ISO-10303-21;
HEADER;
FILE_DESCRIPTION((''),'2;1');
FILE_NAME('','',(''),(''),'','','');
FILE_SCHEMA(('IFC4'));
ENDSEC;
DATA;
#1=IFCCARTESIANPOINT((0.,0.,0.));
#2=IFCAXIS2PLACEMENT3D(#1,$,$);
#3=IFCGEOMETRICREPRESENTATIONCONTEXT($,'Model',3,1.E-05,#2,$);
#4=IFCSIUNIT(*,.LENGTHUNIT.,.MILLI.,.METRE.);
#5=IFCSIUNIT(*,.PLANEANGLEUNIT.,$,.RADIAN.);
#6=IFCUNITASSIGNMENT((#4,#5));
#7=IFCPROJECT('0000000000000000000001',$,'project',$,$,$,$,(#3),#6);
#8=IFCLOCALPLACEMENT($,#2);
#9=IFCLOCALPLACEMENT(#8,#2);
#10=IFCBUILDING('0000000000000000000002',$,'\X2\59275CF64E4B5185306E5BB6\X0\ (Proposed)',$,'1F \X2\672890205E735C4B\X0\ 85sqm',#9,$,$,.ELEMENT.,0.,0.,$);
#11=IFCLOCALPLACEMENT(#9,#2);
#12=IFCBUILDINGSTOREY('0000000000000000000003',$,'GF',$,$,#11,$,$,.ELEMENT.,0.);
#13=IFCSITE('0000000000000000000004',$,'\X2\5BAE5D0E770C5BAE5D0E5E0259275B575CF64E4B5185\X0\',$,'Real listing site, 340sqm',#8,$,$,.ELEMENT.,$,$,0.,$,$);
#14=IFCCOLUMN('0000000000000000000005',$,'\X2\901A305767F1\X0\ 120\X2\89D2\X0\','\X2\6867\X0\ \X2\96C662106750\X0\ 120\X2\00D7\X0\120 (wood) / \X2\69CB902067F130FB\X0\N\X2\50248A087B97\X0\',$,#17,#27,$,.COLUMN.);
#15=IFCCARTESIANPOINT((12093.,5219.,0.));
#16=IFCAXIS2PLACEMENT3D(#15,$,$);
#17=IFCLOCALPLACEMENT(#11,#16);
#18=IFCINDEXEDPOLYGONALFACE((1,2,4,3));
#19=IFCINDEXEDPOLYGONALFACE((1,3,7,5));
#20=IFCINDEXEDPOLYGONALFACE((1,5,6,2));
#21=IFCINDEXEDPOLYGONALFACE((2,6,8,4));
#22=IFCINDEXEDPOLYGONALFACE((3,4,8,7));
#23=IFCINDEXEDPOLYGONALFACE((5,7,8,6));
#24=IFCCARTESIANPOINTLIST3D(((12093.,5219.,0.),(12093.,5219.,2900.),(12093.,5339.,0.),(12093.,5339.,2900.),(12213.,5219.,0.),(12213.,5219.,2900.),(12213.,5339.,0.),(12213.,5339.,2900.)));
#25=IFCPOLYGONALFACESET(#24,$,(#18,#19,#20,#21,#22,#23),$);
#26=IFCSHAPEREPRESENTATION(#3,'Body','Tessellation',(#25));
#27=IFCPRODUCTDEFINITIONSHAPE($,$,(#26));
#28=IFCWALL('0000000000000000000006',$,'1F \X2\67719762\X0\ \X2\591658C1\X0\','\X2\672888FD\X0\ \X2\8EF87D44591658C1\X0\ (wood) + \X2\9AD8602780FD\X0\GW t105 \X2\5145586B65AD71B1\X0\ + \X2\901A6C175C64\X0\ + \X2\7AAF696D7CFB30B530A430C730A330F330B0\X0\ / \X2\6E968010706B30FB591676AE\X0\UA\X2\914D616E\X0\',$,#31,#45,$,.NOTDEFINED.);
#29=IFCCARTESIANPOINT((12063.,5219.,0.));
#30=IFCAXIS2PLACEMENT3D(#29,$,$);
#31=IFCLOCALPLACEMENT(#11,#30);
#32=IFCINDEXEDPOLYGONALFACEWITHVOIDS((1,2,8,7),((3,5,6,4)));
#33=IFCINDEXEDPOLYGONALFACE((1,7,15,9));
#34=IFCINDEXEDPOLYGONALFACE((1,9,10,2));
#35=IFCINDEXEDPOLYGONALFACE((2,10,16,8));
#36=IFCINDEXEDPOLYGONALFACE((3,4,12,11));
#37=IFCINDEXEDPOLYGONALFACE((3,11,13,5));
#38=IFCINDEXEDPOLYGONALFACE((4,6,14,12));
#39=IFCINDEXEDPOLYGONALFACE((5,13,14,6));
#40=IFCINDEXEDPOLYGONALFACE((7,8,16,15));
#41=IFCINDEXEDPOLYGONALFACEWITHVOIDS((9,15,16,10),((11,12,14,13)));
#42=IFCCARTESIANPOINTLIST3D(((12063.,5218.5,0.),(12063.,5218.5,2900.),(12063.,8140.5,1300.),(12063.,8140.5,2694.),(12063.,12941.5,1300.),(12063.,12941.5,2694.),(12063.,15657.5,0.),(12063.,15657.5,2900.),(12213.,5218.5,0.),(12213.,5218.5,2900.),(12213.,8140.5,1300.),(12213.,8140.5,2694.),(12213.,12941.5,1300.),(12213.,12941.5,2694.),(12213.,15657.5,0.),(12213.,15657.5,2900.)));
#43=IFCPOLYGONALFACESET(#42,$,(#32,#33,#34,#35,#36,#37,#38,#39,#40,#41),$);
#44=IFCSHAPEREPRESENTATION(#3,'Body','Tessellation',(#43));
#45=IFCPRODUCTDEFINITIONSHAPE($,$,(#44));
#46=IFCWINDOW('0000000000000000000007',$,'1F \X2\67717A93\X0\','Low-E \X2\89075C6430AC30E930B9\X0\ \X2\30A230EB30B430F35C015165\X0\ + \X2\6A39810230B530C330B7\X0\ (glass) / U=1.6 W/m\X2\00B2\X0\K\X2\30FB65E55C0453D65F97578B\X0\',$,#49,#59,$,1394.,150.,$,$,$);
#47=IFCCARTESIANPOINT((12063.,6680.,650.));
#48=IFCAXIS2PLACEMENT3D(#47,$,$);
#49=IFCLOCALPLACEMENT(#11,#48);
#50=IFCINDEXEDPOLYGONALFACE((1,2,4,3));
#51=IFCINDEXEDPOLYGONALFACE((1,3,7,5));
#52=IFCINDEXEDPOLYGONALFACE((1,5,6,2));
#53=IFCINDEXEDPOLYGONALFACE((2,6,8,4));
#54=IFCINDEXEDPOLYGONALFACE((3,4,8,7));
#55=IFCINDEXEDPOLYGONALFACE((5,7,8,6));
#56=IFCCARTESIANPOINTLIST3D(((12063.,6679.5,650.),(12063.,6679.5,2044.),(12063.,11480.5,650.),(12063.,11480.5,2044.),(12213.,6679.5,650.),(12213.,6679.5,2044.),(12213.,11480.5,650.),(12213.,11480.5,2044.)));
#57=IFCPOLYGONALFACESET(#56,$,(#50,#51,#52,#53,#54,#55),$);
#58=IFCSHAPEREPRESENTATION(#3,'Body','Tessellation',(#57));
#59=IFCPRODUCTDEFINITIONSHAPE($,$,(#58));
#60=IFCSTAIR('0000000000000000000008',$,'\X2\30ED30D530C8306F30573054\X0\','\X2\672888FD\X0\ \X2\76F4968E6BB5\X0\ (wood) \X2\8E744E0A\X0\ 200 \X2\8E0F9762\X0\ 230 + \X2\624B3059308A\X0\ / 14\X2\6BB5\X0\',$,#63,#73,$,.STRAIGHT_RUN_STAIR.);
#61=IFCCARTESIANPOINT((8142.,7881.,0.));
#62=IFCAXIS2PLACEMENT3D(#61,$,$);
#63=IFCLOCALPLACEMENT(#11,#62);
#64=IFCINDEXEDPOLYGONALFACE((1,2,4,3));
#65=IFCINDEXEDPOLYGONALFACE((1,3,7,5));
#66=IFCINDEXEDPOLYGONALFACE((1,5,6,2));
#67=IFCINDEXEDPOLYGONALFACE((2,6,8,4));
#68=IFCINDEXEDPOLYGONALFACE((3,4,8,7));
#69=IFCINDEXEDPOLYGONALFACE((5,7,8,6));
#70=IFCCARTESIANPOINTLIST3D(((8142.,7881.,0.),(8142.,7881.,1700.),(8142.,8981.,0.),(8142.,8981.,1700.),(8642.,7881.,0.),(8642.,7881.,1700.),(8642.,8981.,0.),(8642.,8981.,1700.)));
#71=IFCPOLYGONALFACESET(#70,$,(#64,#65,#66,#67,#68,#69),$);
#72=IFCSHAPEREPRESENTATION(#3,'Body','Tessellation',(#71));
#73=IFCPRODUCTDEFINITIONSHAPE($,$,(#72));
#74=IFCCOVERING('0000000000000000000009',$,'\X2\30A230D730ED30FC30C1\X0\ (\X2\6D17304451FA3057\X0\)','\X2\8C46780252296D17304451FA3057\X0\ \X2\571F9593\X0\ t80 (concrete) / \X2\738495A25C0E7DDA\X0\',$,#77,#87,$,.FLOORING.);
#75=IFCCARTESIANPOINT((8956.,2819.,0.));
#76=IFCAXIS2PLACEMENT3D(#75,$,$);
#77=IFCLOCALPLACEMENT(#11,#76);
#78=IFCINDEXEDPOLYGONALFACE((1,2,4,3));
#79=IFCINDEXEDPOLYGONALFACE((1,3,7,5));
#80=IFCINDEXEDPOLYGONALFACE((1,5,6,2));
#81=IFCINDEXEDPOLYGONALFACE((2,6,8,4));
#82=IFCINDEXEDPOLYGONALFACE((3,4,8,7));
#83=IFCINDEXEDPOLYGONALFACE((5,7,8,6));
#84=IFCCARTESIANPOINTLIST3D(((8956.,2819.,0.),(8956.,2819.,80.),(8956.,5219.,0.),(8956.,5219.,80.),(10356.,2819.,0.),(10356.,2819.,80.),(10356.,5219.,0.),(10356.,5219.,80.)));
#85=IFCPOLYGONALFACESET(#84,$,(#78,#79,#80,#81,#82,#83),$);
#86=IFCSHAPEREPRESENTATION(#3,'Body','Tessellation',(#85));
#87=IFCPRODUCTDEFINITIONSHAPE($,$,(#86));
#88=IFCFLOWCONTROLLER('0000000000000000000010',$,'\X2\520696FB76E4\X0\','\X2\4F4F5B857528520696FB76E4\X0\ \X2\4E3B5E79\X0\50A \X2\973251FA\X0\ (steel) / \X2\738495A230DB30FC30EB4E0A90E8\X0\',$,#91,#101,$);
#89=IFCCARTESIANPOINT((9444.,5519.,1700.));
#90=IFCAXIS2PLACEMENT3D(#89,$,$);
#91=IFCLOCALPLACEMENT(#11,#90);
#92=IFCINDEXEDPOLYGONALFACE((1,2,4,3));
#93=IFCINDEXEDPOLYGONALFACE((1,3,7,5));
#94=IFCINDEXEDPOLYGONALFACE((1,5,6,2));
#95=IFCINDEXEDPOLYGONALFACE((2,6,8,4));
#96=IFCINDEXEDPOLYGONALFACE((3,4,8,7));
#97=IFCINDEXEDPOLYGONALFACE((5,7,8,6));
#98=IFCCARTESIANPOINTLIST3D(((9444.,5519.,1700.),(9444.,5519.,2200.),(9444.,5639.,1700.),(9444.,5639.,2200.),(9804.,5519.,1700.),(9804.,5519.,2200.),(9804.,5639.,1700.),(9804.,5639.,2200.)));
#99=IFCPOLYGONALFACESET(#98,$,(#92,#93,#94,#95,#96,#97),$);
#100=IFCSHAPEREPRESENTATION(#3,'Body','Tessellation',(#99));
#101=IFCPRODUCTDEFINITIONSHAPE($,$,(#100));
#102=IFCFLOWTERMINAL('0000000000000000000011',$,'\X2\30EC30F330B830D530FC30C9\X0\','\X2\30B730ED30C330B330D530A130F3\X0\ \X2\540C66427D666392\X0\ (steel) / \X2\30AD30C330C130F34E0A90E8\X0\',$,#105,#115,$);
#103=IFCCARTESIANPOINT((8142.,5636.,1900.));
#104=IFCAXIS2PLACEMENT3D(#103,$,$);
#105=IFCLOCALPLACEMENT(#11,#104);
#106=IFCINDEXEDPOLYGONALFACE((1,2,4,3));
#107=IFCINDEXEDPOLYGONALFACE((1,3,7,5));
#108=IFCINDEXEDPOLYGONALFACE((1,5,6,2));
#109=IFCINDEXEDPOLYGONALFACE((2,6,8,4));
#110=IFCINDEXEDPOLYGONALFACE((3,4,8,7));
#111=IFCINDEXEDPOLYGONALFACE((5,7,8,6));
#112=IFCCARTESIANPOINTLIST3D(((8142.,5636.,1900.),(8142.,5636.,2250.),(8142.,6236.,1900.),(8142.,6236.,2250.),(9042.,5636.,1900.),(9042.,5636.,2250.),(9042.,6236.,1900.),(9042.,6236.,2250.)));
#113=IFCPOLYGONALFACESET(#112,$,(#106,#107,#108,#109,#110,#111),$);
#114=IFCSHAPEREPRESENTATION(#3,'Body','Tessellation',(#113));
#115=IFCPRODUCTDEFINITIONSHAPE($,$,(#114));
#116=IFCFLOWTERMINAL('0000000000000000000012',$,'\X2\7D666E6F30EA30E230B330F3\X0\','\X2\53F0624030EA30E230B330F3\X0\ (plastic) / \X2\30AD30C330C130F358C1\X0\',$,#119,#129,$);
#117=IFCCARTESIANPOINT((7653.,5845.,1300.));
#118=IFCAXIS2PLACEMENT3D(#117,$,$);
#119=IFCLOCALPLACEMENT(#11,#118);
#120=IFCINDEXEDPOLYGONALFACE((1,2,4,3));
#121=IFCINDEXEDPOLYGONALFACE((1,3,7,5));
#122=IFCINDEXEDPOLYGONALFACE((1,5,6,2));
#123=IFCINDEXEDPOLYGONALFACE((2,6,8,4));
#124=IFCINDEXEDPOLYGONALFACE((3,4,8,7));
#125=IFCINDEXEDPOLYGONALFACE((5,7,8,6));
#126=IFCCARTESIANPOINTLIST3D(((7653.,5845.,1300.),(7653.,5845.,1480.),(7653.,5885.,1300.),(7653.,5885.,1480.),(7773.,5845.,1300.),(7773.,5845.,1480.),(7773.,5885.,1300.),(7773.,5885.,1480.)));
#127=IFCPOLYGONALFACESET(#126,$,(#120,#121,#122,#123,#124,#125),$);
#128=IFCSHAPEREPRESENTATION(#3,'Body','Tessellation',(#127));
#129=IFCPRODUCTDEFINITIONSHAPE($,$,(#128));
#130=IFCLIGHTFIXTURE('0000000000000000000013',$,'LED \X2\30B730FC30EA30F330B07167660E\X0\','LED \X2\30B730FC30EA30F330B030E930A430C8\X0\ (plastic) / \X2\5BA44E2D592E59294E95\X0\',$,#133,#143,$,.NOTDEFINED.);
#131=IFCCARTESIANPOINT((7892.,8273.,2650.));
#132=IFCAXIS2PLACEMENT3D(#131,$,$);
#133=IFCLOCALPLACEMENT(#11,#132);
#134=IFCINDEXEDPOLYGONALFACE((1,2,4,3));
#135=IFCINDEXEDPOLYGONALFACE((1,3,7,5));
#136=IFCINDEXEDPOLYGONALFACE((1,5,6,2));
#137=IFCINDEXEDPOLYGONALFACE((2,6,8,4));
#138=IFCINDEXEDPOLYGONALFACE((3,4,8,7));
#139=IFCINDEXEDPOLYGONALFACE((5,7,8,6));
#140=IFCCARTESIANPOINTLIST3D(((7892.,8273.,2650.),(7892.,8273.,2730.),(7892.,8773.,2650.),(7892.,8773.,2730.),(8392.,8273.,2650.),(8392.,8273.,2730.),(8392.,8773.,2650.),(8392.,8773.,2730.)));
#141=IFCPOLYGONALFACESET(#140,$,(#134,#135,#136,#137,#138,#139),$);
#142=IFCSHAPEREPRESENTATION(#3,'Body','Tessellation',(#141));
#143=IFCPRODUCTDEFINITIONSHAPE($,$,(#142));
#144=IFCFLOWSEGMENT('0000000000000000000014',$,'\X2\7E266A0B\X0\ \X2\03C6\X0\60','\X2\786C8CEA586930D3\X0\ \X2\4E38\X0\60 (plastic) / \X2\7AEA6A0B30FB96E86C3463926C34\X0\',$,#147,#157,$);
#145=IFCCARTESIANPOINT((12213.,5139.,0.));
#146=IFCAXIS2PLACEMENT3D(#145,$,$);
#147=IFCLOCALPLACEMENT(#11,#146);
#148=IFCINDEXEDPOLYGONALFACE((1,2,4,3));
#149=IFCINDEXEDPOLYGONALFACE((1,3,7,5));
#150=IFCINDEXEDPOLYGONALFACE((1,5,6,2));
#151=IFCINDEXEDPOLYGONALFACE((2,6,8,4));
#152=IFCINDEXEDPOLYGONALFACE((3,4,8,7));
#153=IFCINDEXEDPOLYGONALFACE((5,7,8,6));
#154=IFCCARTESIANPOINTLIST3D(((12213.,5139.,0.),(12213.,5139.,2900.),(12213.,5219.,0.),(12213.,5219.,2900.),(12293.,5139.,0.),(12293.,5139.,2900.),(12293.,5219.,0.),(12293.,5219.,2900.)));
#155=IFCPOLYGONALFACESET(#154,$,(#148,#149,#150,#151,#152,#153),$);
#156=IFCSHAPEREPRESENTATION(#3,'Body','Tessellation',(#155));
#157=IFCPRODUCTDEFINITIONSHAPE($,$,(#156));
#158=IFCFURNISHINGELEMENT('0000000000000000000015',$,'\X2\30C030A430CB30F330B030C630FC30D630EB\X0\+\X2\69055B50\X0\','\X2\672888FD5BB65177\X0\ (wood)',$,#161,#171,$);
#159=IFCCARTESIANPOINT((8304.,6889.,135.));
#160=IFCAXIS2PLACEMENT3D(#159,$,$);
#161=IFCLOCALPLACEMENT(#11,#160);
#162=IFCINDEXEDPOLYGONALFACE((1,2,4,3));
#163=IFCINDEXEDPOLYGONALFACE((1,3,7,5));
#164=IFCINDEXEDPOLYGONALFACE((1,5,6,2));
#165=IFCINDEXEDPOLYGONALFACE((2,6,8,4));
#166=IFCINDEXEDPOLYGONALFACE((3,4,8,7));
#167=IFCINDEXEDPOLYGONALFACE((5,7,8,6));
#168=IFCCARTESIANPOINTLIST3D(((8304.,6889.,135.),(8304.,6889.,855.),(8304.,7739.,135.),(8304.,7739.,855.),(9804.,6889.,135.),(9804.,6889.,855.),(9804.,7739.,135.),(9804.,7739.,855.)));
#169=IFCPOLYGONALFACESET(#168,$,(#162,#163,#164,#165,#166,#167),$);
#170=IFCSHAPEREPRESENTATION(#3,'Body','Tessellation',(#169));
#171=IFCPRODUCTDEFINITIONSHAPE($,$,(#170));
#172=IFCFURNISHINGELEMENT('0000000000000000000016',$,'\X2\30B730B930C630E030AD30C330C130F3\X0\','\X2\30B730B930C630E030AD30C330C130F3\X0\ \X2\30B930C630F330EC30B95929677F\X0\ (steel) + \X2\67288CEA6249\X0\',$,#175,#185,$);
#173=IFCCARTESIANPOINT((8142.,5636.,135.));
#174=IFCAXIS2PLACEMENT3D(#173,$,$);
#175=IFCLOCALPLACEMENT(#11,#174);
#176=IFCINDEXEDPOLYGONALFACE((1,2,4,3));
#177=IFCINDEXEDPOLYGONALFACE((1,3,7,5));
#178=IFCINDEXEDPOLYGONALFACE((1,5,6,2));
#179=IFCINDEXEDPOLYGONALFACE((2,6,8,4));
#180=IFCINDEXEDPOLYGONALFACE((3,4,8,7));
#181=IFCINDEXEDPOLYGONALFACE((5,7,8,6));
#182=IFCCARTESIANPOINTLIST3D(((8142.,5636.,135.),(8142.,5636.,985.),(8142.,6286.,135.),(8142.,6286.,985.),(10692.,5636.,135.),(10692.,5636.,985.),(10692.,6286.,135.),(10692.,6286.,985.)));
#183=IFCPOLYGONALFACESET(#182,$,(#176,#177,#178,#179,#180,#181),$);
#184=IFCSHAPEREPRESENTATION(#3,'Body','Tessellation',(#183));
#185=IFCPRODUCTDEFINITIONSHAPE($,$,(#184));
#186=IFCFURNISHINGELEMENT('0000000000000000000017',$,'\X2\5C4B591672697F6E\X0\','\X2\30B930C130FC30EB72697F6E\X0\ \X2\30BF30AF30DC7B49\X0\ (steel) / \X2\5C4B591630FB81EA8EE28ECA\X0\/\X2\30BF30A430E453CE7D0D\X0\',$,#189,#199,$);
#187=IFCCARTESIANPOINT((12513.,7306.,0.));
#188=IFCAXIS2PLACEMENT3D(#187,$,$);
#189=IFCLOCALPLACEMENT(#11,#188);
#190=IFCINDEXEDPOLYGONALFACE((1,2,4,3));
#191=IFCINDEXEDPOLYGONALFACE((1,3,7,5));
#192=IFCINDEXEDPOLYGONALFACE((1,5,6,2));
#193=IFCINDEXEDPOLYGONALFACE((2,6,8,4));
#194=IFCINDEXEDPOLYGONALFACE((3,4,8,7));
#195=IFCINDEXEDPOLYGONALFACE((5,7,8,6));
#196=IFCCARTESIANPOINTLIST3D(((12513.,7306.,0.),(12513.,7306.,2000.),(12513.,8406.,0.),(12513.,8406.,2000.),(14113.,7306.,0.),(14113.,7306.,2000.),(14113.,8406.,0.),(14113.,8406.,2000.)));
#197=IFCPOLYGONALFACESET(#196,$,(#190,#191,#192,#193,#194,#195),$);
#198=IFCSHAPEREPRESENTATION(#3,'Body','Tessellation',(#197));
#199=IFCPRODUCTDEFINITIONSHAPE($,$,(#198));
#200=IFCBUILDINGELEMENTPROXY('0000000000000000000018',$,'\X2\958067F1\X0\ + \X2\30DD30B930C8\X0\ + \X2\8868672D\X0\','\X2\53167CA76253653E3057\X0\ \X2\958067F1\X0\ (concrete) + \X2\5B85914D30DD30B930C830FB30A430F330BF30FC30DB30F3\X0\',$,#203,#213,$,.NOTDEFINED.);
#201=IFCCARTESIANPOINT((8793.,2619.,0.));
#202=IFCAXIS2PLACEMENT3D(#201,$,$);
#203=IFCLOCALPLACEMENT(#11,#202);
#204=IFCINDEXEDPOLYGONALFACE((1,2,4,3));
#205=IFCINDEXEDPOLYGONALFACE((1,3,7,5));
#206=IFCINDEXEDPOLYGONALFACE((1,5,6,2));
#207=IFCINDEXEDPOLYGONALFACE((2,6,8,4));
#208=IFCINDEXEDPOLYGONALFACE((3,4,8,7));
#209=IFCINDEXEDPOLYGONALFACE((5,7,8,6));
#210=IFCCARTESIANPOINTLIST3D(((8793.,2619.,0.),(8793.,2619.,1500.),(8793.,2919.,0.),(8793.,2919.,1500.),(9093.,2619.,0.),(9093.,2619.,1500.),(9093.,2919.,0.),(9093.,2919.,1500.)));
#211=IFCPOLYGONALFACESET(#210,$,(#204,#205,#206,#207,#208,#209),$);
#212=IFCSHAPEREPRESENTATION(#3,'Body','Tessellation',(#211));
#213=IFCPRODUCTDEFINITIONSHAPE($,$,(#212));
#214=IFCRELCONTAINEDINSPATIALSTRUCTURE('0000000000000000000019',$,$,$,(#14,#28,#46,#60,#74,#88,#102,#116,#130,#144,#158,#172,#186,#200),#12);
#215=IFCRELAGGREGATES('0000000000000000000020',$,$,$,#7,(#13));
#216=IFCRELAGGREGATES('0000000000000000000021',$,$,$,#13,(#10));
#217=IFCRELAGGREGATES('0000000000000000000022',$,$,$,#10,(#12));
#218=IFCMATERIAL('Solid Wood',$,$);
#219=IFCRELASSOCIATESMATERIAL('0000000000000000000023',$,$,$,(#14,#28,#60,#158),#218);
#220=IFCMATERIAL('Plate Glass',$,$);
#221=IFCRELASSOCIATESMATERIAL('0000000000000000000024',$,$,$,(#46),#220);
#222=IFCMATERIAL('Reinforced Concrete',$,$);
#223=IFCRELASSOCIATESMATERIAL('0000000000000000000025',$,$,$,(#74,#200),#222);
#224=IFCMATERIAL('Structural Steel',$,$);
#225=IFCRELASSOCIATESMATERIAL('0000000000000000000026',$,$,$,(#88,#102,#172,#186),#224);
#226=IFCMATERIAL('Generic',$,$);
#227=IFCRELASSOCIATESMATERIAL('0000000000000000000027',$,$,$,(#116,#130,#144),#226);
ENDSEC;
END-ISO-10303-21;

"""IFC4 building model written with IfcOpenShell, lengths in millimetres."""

from ifc_helpers import new_model, si_unit, frame, frame_2d, origin, place, context, project, spatial, rectangle, extrude, material, element, fill, save


model = new_model("IFC4")

# Units and contexts
model_context = context("Model", 3, precision=1e-05, world=origin())
ifc_project = project(units=[si_unit("LENGTHUNIT", "METRE", prefix="MILLI"), si_unit("PLANEANGLEUNIT", "RADIAN")], contexts=[model_context])

# Site, building, storey
site_placement = place(None, origin())
site = spatial("IfcSite", under=ifc_project, at=site_placement, Name="宮崎県宮崎市大字島之内", ObjectType="Real listing site, 340sqm", CompositionType="ELEMENT", RefElevation=0.0)
building_placement = place(site_placement, origin())
building = spatial("IfcBuilding", under=site, at=building_placement, Name="大島之内の家 (Proposed)", ObjectType="1F 木造平屋 85sqm", CompositionType="ELEMENT", ElevationOfRefHeight=0.0, ElevationOfTerrain=0.0)
storey_placement = place(building_placement, origin())
storey = spatial("IfcBuildingStorey", under=building, at=storey_placement, Name="GF", CompositionType="ELEMENT", Elevation=0.0)

# Column
ifc_material_1 = material(Name="Solid Wood")
column_1_placement = place(storey_placement, frame((12093.0, 5219.0, 0.0)))
element("IfcColumn", 1, at=column_1_placement, inside=storey, material=ifc_material_1, Name="通し柱 120角", Description="桧 集成材 120×120 (wood) / 構造柱・N値計算", PredefinedType="COLUMN", context=model_context, shape_type="SweptSolid", body=[
    extrude(rectangle(XDim=120.0, YDim=120.0, at=frame_2d((60.0, 60.0))), frame((12093.0, 5219.0, 0.0)), (0.0, 0.0, 1.0), 2900.0),
])

# Wall, opening, window
wall_1_placement = place(storey_placement, frame((12063.0, 5219.0, 0.0)))
wall_1 = element("IfcWall", 2, at=wall_1_placement, inside=storey, material=ifc_material_1, Name="1F 東面 外壁", Description="木製 軸組外壁 (wood) + 高性能GW t105 充填断熱 + 通気層 + 窯業系サイディング / 準耐火・外皮UA配慮", PredefinedType="NOTDEFINED", context=model_context, shape_type="SweptSolid", body=[
    extrude(rectangle(XDim=150.0, YDim=10439.0, at=frame_2d((75.0, 5219.0))), frame((12063.0, 5219.0, 0.0)), (0.0, 0.0, 1.0), 2900.0),
])
opening_placement = place(storey_placement, frame((12063.0, 6680.0, 650.0)))
opening = element("IfcOpeningElement", 3, at=opening_placement, cuts=wall_1, PredefinedType="NOTDEFINED", context=model_context, shape_type="SweptSolid", body=[
    extrude(rectangle(XDim=150.0, YDim=4801.0, at=frame_2d((75.0, 2400.0))), frame((12063.0, 6680.0, 650.0)), (0.0, 0.0, 1.0), 1394.0),
])
ifc_material_2 = material(Name="Plate Glass")
window_placement = place(storey_placement, frame((12063.0, 6680.0, 650.0)))
window = element("IfcWindow", 4, at=window_placement, inside=storey, material=ifc_material_2, Name="1F 東窓", Description="Low-E 複層ガラス アルゴン封入 + 樹脂サッシ (glass) / U=1.6 W/m²K・日射取得型", OverallHeight=1394.0, OverallWidth=150.0, context=model_context, shape_type="SweptSolid", body=[
    extrude(rectangle(XDim=150.0, YDim=4801.0, at=frame_2d((75.0, 2400.0))), frame((12063.0, 6680.0, 650.0)), (0.0, 0.0, 1.0), 1394.0),
])
fill(opening, window)

# Stair
stair_placement = place(storey_placement, frame((8142.0, 7881.0, 0.0)))
element("IfcStair", 5, at=stair_placement, inside=storey, material=ifc_material_1, Name="ロフトはしご", Description="木製 直階段 (wood) 蹴上 200 踏面 230 + 手すり / 14段", PredefinedType="STRAIGHT_RUN_STAIR", context=model_context, shape_type="SweptSolid", body=[
    extrude(rectangle(XDim=500.0, YDim=1100.0, at=frame_2d((250.0, 550.0))), frame((8142.0, 7881.0, 0.0)), (0.0, 0.0, 1.0), 1700.0),
])

# Covering
ifc_material_3 = material(Name="Reinforced Concrete")
covering_placement = place(storey_placement, frame((8956.0, 2819.0, 0.0)))
element("IfcCovering", 6, at=covering_placement, inside=storey, material=ifc_material_3, Name="アプローチ (洗い出し)", Description="豆砂利洗い出し 土間 t80 (concrete) / 玄関導線", PredefinedType="FLOORING", context=model_context, shape_type="SweptSolid", body=[
    extrude(rectangle(XDim=1400.0, YDim=2400.0, at=frame_2d((700.0, 1200.0))), frame((8956.0, 2819.0, 0.0)), (0.0, 0.0, 1.0), 80.0),
])

# Flow controller
ifc_material_4 = material(Name="Structural Steel")
flow_controller_placement = place(storey_placement, frame((9444.0, 5519.0, 1700.0)))
element("IfcFlowController", 7, at=flow_controller_placement, inside=storey, material=ifc_material_4, Name="分電盤", Description="住宅用分電盤 主幹50A 露出 (steel) / 玄関ホール上部", context=model_context, shape_type="SweptSolid", body=[
    extrude(rectangle(XDim=360.0, YDim=120.0, at=frame_2d((180.0, 60.0))), frame((9444.0, 5519.0, 1700.0)), (0.0, 0.0, 1.0), 500.0),
])

# Flow terminals
flow_terminal_1_placement = place(storey_placement, frame((8142.0, 5636.0, 1900.0)))
element("IfcFlowTerminal", 8, at=flow_terminal_1_placement, inside=storey, material=ifc_material_4, Name="レンジフード", Description="シロッコファン 同時給排 (steel) / キッチン上部", context=model_context, shape_type="SweptSolid", body=[
    extrude(rectangle(XDim=900.0, YDim=600.0, at=frame_2d((450.0, 300.0))), frame((8142.0, 5636.0, 1900.0)), (0.0, 0.0, 1.0), 350.0),
])
ifc_material_5 = material(Name="Generic")
flow_terminal_2_placement = place(storey_placement, frame((7653.0, 5845.0, 1300.0)))
element("IfcFlowTerminal", 9, at=flow_terminal_2_placement, inside=storey, material=ifc_material_5, Name="給湯リモコン", Description="台所リモコン (plastic) / キッチン壁", context=model_context, shape_type="SweptSolid", body=[
    extrude(rectangle(XDim=120.0, YDim=40.0, at=frame_2d((60.0, 20.0))), frame((7653.0, 5845.0, 1300.0)), (0.0, 0.0, 1.0), 180.0),
])

# Light fixture
light_fixture_placement = place(storey_placement, frame((7892.0, 8273.0, 2650.0)))
element("IfcLightFixture", 10, at=light_fixture_placement, inside=storey, material=ifc_material_5, Name="LED シーリング照明", Description="LED シーリングライト (plastic) / 室中央天井", PredefinedType="NOTDEFINED", context=model_context, shape_type="SweptSolid", body=[
    extrude(rectangle(XDim=500.0, YDim=500.0, at=frame_2d((250.0, 250.0))), frame((7892.0, 8273.0, 2650.0)), (0.0, 0.0, 1.0), 80.0),
])

# Flow segment
flow_segment_placement = place(storey_placement, frame((12213.0, 5139.0, 0.0)))
element("IfcFlowSegment", 11, at=flow_segment_placement, inside=storey, material=ifc_material_5, Name="縦樋 φ60", Description="硬質塩ビ 丸60 (plastic) / 竪樋・雨水排水", context=model_context, shape_type="SweptSolid", body=[
    extrude(rectangle(XDim=80.0, YDim=80.0, at=frame_2d((40.0, 40.0))), frame((12213.0, 5139.0, 0.0)), (0.0, 0.0, 1.0), 2900.0),
])

# Furnishing elements
furnishing_1_placement = place(storey_placement, frame((8304.0, 6889.0, 135.0)))
element("IfcFurnishingElement", 12, at=furnishing_1_placement, inside=storey, material=ifc_material_1, Name="ダイニングテーブル+椅子", Description="木製家具 (wood)", context=model_context, shape_type="SweptSolid", body=[
    extrude(rectangle(XDim=1500.0, YDim=850.0, at=frame_2d((750.0, 425.0))), frame((8304.0, 6889.0, 135.0)), (0.0, 0.0, 1.0), 720.0),
])
furnishing_2_placement = place(storey_placement, frame((8142.0, 5636.0, 135.0)))
element("IfcFurnishingElement", 13, at=furnishing_2_placement, inside=storey, material=ifc_material_4, Name="システムキッチン", Description="システムキッチン ステンレス天板 (steel) + 木質扉", context=model_context, shape_type="SweptSolid", body=[
    extrude(rectangle(XDim=2550.0, YDim=650.0, at=frame_2d((1275.0, 325.0))), frame((8142.0, 5636.0, 135.0)), (0.0, 0.0, 1.0), 850.0),
])
furnishing_3_placement = place(storey_placement, frame((12513.0, 7306.0, 0.0)))
element("IfcFurnishingElement", 14, at=furnishing_3_placement, inside=storey, material=ifc_material_4, Name="屋外物置", Description="スチール物置 タクボ等 (steel) / 屋外・自転車/タイヤ収納", context=model_context, shape_type="SweptSolid", body=[
    extrude(rectangle(XDim=1600.0, YDim=1100.0, at=frame_2d((800.0, 550.0))), frame((12513.0, 7306.0, 0.0)), (0.0, 0.0, 1.0), 2000.0),
])

# Building element proxy
proxy_placement = place(storey_placement, frame((8793.0, 2619.0, 0.0)))
element("IfcBuildingElementProxy", 15, at=proxy_placement, inside=storey, material=ifc_material_3, Name="門柱 + ポスト + 表札", Description="化粧打放し 門柱 (concrete) + 宅配ポスト・インターホン", PredefinedType="NOTDEFINED", context=model_context, shape_type="SweptSolid", body=[
    extrude(rectangle(XDim=300.0, YDim=300.0, at=frame_2d((150.0, 150.0))), frame((8793.0, 2619.0, 0.0)), (0.0, 0.0, 1.0), 1500.0),
])

save(model, "model.ifc")
